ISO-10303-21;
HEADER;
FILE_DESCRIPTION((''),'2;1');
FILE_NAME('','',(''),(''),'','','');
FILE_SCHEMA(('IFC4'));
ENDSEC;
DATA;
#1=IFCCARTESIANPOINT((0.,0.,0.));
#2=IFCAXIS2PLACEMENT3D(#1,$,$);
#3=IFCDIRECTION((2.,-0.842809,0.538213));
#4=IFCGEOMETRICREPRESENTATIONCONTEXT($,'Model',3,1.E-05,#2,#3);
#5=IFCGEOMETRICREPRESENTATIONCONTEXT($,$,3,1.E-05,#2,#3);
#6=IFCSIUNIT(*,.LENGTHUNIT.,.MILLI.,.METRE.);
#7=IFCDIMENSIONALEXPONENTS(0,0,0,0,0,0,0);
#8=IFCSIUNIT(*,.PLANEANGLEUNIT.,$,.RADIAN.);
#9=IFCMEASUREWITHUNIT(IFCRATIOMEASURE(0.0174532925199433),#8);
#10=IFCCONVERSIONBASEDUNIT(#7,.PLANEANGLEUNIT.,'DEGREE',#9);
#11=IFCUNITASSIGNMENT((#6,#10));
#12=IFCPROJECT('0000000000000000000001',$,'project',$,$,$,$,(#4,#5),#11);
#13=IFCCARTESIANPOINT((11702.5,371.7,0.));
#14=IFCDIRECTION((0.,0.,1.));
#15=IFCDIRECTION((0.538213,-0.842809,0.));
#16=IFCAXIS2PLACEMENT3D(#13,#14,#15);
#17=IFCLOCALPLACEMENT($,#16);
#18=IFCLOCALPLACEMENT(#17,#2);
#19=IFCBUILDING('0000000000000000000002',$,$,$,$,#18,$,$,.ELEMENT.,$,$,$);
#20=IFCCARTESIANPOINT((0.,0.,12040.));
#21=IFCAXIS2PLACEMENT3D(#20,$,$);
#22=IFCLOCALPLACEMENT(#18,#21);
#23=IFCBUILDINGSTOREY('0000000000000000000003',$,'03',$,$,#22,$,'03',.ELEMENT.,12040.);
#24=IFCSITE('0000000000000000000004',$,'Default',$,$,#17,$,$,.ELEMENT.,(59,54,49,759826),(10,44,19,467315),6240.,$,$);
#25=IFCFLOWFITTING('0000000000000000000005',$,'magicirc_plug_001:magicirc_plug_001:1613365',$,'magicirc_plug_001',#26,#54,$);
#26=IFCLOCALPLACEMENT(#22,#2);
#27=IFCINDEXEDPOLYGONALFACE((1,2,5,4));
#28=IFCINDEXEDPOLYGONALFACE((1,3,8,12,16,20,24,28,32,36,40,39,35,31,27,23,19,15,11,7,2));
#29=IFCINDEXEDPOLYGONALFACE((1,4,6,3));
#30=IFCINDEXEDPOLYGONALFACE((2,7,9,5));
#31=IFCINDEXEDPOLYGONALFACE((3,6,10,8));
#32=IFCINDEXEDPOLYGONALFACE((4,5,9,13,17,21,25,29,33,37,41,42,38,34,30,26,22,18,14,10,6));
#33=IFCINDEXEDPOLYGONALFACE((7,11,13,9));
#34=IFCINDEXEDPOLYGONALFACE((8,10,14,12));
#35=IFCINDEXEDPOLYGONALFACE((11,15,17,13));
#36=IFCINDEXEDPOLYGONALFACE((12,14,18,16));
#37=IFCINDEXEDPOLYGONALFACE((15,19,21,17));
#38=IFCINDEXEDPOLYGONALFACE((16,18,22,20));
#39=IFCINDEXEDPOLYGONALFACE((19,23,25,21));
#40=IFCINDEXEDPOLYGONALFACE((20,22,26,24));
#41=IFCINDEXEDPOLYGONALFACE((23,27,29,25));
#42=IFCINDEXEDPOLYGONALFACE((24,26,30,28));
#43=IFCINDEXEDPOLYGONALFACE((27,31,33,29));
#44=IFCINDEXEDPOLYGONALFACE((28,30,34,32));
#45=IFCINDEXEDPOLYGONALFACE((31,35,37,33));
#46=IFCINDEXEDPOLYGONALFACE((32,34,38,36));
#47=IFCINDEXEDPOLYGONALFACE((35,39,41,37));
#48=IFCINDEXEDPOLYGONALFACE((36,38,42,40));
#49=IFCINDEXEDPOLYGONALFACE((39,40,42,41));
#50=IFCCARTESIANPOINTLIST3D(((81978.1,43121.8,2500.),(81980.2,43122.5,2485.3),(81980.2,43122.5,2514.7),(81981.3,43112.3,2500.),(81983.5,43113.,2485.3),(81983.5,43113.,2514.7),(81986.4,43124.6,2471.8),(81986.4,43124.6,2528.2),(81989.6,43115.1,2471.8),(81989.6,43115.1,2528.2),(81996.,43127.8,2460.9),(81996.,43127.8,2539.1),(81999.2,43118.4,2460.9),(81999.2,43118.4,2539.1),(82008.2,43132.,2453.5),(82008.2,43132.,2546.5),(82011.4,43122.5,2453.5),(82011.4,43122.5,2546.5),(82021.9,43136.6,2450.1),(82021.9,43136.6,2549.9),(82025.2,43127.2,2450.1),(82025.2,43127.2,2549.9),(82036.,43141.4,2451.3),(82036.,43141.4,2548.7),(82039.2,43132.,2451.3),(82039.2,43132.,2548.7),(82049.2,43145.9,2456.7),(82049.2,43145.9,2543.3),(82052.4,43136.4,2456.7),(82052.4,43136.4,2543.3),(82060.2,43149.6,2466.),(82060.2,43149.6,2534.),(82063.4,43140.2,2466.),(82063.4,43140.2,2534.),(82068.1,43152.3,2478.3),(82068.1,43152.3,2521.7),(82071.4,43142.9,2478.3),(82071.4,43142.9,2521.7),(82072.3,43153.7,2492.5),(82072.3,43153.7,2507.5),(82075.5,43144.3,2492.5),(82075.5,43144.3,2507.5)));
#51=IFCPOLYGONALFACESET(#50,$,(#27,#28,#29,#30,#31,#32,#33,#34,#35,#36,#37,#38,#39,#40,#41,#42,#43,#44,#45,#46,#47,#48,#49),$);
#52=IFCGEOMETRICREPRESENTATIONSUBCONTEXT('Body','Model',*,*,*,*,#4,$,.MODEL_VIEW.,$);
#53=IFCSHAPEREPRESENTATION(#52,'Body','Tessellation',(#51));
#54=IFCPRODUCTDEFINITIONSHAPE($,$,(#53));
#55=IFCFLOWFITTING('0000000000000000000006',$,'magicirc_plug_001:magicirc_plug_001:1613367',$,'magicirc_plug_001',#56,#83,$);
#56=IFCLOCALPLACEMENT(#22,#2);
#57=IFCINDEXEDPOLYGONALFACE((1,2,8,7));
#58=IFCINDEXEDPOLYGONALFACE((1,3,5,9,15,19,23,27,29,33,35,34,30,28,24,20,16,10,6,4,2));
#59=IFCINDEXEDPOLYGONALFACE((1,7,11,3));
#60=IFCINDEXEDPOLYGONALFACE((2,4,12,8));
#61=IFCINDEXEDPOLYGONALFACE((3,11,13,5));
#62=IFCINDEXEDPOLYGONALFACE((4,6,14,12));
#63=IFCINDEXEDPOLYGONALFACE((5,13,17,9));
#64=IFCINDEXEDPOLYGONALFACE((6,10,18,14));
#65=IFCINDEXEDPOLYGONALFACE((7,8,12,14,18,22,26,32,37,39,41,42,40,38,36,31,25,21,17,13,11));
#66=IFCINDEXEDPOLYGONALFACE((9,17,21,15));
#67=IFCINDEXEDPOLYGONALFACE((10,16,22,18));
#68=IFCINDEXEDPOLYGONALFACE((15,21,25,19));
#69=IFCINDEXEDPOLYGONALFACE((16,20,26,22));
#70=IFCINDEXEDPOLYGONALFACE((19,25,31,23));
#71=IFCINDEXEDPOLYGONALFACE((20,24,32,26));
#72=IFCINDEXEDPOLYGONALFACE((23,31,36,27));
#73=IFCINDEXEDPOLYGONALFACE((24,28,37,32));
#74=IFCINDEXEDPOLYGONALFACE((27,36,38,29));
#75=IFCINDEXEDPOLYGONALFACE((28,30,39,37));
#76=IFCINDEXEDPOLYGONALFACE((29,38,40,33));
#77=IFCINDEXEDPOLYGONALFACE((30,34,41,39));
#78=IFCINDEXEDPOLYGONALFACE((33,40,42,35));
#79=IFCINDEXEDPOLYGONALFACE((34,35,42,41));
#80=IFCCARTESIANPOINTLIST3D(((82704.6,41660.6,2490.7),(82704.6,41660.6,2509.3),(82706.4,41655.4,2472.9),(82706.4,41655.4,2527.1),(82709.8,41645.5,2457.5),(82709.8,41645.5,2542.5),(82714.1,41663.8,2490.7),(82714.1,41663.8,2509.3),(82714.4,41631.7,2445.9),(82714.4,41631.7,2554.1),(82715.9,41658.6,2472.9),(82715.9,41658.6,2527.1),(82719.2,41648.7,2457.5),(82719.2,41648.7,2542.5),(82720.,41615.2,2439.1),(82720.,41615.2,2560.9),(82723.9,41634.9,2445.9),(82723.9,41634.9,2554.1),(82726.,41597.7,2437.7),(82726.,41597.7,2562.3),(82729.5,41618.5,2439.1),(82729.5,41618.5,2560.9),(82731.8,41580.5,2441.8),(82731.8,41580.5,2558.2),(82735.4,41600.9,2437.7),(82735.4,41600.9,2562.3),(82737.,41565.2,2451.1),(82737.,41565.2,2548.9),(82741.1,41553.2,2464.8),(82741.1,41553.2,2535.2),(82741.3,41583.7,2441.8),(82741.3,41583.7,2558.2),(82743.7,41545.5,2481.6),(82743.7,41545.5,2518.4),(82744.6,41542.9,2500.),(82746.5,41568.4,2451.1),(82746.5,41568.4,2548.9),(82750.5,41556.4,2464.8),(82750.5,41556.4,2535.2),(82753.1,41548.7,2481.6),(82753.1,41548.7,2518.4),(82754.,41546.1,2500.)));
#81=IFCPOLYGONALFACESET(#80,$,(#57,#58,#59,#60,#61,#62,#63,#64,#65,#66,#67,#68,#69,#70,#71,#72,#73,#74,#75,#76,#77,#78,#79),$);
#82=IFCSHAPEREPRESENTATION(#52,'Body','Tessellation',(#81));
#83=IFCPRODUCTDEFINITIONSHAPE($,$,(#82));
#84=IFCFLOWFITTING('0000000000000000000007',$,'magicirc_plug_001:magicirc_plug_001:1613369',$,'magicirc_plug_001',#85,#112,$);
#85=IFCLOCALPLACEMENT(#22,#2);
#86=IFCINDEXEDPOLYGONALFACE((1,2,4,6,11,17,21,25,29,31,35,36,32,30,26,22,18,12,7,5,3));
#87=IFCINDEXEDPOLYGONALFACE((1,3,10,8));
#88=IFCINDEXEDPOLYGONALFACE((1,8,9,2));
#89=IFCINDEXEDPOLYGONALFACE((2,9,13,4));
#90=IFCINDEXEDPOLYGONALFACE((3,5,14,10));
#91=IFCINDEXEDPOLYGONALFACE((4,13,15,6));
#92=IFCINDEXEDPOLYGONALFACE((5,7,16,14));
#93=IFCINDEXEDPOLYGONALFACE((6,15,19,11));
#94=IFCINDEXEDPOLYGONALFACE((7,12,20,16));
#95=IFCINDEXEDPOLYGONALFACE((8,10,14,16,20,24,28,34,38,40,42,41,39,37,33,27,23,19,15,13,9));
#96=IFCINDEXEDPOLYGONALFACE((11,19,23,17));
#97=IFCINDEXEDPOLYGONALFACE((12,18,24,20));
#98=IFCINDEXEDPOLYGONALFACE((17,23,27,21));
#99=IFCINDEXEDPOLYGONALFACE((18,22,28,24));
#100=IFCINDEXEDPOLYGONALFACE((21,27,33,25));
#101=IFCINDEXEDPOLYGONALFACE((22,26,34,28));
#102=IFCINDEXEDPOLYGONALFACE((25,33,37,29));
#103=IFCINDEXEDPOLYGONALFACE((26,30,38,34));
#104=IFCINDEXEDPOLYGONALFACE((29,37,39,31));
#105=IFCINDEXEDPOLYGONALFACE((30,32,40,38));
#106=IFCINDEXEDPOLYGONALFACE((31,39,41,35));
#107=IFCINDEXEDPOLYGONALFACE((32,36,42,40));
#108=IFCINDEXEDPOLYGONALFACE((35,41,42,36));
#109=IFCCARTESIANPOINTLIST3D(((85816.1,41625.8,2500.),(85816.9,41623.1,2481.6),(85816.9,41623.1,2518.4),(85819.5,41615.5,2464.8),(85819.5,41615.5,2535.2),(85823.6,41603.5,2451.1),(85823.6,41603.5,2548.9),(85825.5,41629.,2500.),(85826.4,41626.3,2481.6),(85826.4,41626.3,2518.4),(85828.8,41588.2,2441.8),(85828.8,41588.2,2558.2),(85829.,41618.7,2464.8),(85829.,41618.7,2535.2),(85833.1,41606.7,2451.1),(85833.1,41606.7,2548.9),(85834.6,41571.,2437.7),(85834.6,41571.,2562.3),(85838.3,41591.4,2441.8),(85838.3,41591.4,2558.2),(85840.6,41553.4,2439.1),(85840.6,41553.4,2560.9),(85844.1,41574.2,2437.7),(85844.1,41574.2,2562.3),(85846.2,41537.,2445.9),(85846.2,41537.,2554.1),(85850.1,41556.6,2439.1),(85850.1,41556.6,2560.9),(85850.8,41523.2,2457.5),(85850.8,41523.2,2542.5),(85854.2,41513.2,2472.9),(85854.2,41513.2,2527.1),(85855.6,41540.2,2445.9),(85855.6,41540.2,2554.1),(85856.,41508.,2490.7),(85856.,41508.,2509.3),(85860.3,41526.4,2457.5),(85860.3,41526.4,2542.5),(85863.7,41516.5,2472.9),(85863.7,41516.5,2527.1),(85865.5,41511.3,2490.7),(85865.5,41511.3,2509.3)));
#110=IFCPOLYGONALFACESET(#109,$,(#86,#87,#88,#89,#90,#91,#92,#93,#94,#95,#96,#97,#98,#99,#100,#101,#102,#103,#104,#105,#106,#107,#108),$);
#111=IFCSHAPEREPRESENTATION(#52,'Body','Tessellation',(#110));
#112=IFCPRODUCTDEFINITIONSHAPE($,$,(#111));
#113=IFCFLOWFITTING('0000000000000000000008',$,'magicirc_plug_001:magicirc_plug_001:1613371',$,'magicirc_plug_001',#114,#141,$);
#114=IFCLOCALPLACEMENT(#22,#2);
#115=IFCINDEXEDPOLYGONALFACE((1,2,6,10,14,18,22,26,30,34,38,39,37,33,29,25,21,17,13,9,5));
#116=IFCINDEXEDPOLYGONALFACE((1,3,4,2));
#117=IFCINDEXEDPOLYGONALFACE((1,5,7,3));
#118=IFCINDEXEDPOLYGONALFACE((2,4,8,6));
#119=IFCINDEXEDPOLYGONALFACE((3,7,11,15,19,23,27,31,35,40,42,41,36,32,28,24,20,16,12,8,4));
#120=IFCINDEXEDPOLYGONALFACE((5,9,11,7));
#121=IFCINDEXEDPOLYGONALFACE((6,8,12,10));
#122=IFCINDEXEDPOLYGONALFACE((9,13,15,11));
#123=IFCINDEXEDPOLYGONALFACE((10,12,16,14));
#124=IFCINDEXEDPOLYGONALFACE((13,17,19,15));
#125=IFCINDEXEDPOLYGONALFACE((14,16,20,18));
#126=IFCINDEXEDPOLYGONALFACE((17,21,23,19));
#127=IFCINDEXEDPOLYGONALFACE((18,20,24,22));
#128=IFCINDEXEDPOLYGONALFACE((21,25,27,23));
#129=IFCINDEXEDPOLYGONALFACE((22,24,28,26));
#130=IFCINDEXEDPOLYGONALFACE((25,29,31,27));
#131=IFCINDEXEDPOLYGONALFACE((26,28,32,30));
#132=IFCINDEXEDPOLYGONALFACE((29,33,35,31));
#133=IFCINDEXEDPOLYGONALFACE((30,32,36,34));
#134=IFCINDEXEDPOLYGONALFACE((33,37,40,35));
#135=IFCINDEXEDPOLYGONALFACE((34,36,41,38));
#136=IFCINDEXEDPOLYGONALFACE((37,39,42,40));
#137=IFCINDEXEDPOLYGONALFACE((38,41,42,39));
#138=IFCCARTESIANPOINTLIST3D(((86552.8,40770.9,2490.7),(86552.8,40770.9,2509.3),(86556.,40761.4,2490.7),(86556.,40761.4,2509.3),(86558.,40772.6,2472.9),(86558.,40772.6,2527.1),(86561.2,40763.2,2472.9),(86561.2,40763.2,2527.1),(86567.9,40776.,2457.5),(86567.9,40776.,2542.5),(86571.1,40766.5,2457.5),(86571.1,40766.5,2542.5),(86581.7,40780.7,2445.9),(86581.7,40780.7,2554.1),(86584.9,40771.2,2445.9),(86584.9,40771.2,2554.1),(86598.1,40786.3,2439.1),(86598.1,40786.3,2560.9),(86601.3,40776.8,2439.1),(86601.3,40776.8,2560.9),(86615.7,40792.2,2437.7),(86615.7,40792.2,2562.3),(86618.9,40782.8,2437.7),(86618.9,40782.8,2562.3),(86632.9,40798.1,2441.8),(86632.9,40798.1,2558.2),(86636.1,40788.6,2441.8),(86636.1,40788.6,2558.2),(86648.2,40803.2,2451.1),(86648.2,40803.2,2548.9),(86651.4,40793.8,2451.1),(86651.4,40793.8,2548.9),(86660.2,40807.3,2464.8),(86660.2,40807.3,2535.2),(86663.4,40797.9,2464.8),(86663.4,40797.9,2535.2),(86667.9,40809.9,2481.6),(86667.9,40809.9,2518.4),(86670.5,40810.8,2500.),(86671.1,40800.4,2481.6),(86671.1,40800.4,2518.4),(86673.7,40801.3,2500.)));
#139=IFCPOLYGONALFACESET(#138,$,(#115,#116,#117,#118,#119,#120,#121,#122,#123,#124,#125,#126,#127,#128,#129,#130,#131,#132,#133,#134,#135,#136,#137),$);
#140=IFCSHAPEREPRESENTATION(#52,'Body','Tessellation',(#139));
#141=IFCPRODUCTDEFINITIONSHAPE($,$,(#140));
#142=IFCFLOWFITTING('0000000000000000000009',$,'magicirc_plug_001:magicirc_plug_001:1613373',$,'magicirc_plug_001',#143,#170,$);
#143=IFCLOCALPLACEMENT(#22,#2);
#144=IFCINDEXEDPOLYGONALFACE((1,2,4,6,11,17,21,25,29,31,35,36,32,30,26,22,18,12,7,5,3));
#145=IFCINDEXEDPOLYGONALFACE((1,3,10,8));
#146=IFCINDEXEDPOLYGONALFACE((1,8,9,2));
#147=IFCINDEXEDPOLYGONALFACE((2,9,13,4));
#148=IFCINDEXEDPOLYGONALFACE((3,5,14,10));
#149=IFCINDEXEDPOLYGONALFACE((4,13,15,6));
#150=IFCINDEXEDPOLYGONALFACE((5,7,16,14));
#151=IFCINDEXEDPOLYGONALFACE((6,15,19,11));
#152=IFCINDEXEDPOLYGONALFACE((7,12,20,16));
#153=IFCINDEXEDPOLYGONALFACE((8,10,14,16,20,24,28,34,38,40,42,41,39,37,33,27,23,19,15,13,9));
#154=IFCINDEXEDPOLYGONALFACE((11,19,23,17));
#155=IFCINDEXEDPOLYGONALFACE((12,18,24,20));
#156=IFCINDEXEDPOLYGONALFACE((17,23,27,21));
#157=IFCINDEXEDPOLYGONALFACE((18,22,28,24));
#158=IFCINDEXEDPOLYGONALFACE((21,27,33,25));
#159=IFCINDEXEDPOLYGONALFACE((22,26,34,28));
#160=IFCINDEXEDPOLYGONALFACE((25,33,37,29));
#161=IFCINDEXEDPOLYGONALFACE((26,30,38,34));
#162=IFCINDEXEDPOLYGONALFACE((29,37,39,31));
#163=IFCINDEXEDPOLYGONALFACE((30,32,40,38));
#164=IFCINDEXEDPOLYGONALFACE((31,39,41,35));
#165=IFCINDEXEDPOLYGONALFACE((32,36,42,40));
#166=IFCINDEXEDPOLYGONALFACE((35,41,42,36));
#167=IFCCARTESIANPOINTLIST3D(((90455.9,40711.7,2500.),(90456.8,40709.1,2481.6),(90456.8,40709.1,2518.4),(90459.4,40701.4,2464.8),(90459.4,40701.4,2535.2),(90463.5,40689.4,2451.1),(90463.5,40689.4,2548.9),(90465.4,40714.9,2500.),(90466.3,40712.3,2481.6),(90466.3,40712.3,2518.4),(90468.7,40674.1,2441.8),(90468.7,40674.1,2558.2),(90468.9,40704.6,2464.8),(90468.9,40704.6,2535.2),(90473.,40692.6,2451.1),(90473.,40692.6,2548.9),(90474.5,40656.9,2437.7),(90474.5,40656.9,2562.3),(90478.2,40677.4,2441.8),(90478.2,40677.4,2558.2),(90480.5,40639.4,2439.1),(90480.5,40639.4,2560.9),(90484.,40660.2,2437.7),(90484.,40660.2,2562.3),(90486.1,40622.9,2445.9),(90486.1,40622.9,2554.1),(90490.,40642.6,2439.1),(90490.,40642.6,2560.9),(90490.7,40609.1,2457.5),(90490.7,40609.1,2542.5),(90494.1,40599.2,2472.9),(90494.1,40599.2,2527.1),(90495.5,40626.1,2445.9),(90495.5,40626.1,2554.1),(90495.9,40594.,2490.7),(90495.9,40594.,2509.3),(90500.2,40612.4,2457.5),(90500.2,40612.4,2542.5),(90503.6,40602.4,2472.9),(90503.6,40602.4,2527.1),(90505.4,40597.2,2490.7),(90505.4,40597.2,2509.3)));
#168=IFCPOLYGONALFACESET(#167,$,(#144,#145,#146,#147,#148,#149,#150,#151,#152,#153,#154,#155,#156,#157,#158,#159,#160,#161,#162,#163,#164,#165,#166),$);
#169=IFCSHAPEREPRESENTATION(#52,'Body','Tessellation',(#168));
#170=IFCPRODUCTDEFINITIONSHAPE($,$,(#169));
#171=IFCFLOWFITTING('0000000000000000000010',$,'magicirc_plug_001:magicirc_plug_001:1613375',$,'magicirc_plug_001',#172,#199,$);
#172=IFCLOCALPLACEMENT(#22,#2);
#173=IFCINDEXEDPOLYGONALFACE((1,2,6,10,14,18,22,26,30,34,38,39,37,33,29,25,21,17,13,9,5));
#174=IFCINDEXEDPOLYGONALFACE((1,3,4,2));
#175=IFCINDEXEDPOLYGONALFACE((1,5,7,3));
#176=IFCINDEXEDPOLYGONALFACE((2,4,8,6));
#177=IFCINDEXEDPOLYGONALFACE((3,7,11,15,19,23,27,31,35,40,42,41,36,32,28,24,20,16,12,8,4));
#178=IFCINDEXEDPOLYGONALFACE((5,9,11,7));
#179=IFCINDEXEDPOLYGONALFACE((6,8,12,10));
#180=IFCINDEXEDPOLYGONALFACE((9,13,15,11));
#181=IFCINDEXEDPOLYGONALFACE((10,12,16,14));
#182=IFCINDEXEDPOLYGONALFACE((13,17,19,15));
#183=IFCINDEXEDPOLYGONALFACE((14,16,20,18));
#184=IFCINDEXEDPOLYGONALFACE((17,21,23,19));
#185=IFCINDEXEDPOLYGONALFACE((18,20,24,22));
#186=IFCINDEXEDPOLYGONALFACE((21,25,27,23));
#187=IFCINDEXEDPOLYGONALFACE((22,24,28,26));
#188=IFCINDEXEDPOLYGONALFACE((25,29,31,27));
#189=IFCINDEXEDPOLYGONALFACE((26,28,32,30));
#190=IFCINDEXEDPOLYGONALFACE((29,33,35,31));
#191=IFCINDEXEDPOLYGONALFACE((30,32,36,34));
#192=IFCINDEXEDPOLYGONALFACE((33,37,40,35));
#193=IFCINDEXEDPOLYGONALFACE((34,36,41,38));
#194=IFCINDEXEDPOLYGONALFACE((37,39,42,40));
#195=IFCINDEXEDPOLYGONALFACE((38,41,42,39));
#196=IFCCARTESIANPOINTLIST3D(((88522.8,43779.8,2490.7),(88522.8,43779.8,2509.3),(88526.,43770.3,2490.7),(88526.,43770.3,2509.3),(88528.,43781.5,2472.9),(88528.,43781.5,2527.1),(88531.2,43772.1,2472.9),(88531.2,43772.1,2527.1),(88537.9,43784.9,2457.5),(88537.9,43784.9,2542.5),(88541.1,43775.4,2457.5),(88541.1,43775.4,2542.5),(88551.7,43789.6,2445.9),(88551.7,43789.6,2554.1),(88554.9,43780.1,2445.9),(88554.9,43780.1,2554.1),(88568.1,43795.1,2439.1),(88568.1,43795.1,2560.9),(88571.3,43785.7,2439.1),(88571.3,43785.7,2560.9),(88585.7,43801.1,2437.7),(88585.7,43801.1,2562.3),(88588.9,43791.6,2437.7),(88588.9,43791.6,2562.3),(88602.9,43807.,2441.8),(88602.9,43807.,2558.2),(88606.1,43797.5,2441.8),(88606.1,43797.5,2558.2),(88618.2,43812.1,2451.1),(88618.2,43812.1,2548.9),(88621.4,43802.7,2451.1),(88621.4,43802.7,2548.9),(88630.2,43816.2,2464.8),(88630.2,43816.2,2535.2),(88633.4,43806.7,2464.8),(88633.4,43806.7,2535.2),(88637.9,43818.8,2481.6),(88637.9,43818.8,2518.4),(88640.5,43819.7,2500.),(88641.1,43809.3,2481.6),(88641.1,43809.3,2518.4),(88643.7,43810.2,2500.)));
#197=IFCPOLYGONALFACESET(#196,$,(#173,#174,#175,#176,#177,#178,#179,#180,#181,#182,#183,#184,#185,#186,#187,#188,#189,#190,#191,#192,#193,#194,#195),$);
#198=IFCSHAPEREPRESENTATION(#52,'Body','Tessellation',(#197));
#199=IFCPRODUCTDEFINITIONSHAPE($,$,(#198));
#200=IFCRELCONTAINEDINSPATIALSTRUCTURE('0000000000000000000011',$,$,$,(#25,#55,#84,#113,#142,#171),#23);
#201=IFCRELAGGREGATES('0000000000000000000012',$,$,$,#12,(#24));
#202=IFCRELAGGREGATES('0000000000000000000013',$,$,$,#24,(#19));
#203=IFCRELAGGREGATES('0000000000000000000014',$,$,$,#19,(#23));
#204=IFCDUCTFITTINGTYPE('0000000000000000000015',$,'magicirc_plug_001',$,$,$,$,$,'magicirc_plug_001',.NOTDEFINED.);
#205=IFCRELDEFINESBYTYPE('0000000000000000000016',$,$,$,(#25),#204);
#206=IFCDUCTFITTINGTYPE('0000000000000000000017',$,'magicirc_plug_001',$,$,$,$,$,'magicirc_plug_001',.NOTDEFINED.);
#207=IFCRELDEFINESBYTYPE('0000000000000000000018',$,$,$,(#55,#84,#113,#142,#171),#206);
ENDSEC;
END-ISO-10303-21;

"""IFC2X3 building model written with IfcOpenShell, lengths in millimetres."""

from ifc_helpers import new_model, entity, si_unit, converted_unit, direction, frame, frame_2d, origin, place, context, subcontext, project, spatial, circle, extrude, source, transform, mapped, type_object, type_shapes, element, save


model = new_model("IFC2X3")

# Units and contexts
model_context = context("Model", 3, precision=1e-05, world=origin(), true_north=direction((2.0, -0.842809, 0.538213)))
context_of_model = context(None, 3, precision=1e-05, world=origin(), true_north=direction((2.0, -0.842809, 0.538213)))
body_context = subcontext(model_context, "Body", "Model", "MODEL_VIEW")
ifc_project = project(units=[si_unit("LENGTHUNIT", "METRE", prefix="MILLI"), converted_unit("PLANEANGLEUNIT", "DEGREE", entity("IfcRatioMeasure", 0.0174532925199433), si_unit("PLANEANGLEUNIT", "RADIAN"), dimensions=[0, 0, 0, 0, 0, 0, 0])], contexts=[model_context, context_of_model])

# Site, building, storey
site_placement = place(None, frame((11702.5, 371.7, 0.0), z_axis=(0.0, 0.0, 1.0), x_axis=(0.538213, -0.842809, 0.0)))
site = spatial("IfcSite", under=ifc_project, at=site_placement, Name="Default", CompositionType="ELEMENT", RefLatitude=(59, 54, 49, 759826), RefLongitude=(10, 44, 19, 467315), RefElevation=6240.0)
building_placement = place(site_placement, origin())
building = spatial("IfcBuilding", under=site, at=building_placement, CompositionType="ELEMENT")
storey_placement = place(building_placement, frame((0.0, 0.0, 12040.0)))
storey = spatial("IfcBuildingStorey", under=building, at=storey_placement, Name="03", LongName="03", CompositionType="ELEMENT", Elevation=12040.0)

# Flow fittings
duct_fitting_type_1 = type_object("IfcDuctFittingType", Name="magicirc_plug_001", ElementType="magicirc_plug_001", PredefinedType="NOTDEFINED")
shared_shape_1 = source(origin(), body_context, "Body", "SweptSolid", [
    extrude(circle(Radius=50.0, at=frame_2d((0.0, 0.0), x_axis=(1.0, 0.0))), frame((0.0, 0.0, 0.0), z_axis=(1.0, 0.0, 0.0), x_axis=(0.0, 1.0, 0.0)), (0.0, 0.0, 1.0), 10.0),
])
type_shapes(duct_fitting_type_1, [shared_shape_1])
flow_fitting_placement = place(storey_placement, frame((82028.7, 43128.4, 2500.0), z_axis=(0.0, 0.0, 1.0), x_axis=(-0.321274, 0.946986, 0.0)))
element("IfcFlowFitting", 1, at=flow_fitting_placement, inside=storey, type_object=duct_fitting_type_1, Name="magicirc_plug_001:magicirc_plug_001:1613365", ObjectType="magicirc_plug_001", context=body_context, shape_type="MappedRepresentation", body=[
    mapped(shared_shape_1, transform((0.0, 0.0, 0.0), scale=1.0)),
])
duct_fitting_type_2 = type_object("IfcDuctFittingType", Name="magicirc_plug_001", ElementType="magicirc_plug_001", PredefinedType="NOTDEFINED")
shared_shape_2 = source(origin(), body_context, "Body", "SweptSolid", [
    extrude(circle(Radius=62.5, at=frame_2d((0.0, 0.0), x_axis=(1.0, 0.0))), frame((0.0, 0.0, 0.0), z_axis=(1.0, 0.0, 0.0), x_axis=(0.0, 1.0, 0.0)), (0.0, 0.0, 1.0), 10.0),
])
type_shapes(duct_fitting_type_2, [shared_shape_2])
for number, where, z_axis, x_axis, name in (
    (2, (82733.9, 41605.3, 2500.0), (0.0, 0.0, 1.0), (-0.946986, -0.321274, 0.0), "magicirc_plug_001:magicirc_plug_001:1613367"),
    (3, (85836.1, 41566.6, 2500.0), (0.0, 0.0, 1.0), (0.946986, 0.321274, 0.0), "magicirc_plug_001:magicirc_plug_001:1613369"),
    (4, (86611.3, 40790.7, 2500.0), (0.0, 0.0, 1.0), (0.321274, -0.946986, 0.0), "magicirc_plug_001:magicirc_plug_001:1613371"),
    (5, (90476.0, 40652.5, 2500.0), (0.0, 0.0, 1.0), (0.946986, 0.321274, 0.0), "magicirc_plug_001:magicirc_plug_001:1613373"),
    (6, (88581.3, 43799.6, 2500.0), (0.0, 0.0, 1.0), (0.321274, -0.946986, 0.0), "magicirc_plug_001:magicirc_plug_001:1613375"),
):
    element("IfcFlowFitting", number, at=place(storey_placement, frame(where, z_axis=z_axis, x_axis=x_axis)), inside=storey, type_object=duct_fitting_type_2, Name=name, ObjectType="magicirc_plug_001", context=body_context, shape_type="MappedRepresentation", body=[
        mapped(shared_shape_2, transform((0.0, 0.0, 0.0), scale=1.0)),
    ])

save(model, "model.ifc")
